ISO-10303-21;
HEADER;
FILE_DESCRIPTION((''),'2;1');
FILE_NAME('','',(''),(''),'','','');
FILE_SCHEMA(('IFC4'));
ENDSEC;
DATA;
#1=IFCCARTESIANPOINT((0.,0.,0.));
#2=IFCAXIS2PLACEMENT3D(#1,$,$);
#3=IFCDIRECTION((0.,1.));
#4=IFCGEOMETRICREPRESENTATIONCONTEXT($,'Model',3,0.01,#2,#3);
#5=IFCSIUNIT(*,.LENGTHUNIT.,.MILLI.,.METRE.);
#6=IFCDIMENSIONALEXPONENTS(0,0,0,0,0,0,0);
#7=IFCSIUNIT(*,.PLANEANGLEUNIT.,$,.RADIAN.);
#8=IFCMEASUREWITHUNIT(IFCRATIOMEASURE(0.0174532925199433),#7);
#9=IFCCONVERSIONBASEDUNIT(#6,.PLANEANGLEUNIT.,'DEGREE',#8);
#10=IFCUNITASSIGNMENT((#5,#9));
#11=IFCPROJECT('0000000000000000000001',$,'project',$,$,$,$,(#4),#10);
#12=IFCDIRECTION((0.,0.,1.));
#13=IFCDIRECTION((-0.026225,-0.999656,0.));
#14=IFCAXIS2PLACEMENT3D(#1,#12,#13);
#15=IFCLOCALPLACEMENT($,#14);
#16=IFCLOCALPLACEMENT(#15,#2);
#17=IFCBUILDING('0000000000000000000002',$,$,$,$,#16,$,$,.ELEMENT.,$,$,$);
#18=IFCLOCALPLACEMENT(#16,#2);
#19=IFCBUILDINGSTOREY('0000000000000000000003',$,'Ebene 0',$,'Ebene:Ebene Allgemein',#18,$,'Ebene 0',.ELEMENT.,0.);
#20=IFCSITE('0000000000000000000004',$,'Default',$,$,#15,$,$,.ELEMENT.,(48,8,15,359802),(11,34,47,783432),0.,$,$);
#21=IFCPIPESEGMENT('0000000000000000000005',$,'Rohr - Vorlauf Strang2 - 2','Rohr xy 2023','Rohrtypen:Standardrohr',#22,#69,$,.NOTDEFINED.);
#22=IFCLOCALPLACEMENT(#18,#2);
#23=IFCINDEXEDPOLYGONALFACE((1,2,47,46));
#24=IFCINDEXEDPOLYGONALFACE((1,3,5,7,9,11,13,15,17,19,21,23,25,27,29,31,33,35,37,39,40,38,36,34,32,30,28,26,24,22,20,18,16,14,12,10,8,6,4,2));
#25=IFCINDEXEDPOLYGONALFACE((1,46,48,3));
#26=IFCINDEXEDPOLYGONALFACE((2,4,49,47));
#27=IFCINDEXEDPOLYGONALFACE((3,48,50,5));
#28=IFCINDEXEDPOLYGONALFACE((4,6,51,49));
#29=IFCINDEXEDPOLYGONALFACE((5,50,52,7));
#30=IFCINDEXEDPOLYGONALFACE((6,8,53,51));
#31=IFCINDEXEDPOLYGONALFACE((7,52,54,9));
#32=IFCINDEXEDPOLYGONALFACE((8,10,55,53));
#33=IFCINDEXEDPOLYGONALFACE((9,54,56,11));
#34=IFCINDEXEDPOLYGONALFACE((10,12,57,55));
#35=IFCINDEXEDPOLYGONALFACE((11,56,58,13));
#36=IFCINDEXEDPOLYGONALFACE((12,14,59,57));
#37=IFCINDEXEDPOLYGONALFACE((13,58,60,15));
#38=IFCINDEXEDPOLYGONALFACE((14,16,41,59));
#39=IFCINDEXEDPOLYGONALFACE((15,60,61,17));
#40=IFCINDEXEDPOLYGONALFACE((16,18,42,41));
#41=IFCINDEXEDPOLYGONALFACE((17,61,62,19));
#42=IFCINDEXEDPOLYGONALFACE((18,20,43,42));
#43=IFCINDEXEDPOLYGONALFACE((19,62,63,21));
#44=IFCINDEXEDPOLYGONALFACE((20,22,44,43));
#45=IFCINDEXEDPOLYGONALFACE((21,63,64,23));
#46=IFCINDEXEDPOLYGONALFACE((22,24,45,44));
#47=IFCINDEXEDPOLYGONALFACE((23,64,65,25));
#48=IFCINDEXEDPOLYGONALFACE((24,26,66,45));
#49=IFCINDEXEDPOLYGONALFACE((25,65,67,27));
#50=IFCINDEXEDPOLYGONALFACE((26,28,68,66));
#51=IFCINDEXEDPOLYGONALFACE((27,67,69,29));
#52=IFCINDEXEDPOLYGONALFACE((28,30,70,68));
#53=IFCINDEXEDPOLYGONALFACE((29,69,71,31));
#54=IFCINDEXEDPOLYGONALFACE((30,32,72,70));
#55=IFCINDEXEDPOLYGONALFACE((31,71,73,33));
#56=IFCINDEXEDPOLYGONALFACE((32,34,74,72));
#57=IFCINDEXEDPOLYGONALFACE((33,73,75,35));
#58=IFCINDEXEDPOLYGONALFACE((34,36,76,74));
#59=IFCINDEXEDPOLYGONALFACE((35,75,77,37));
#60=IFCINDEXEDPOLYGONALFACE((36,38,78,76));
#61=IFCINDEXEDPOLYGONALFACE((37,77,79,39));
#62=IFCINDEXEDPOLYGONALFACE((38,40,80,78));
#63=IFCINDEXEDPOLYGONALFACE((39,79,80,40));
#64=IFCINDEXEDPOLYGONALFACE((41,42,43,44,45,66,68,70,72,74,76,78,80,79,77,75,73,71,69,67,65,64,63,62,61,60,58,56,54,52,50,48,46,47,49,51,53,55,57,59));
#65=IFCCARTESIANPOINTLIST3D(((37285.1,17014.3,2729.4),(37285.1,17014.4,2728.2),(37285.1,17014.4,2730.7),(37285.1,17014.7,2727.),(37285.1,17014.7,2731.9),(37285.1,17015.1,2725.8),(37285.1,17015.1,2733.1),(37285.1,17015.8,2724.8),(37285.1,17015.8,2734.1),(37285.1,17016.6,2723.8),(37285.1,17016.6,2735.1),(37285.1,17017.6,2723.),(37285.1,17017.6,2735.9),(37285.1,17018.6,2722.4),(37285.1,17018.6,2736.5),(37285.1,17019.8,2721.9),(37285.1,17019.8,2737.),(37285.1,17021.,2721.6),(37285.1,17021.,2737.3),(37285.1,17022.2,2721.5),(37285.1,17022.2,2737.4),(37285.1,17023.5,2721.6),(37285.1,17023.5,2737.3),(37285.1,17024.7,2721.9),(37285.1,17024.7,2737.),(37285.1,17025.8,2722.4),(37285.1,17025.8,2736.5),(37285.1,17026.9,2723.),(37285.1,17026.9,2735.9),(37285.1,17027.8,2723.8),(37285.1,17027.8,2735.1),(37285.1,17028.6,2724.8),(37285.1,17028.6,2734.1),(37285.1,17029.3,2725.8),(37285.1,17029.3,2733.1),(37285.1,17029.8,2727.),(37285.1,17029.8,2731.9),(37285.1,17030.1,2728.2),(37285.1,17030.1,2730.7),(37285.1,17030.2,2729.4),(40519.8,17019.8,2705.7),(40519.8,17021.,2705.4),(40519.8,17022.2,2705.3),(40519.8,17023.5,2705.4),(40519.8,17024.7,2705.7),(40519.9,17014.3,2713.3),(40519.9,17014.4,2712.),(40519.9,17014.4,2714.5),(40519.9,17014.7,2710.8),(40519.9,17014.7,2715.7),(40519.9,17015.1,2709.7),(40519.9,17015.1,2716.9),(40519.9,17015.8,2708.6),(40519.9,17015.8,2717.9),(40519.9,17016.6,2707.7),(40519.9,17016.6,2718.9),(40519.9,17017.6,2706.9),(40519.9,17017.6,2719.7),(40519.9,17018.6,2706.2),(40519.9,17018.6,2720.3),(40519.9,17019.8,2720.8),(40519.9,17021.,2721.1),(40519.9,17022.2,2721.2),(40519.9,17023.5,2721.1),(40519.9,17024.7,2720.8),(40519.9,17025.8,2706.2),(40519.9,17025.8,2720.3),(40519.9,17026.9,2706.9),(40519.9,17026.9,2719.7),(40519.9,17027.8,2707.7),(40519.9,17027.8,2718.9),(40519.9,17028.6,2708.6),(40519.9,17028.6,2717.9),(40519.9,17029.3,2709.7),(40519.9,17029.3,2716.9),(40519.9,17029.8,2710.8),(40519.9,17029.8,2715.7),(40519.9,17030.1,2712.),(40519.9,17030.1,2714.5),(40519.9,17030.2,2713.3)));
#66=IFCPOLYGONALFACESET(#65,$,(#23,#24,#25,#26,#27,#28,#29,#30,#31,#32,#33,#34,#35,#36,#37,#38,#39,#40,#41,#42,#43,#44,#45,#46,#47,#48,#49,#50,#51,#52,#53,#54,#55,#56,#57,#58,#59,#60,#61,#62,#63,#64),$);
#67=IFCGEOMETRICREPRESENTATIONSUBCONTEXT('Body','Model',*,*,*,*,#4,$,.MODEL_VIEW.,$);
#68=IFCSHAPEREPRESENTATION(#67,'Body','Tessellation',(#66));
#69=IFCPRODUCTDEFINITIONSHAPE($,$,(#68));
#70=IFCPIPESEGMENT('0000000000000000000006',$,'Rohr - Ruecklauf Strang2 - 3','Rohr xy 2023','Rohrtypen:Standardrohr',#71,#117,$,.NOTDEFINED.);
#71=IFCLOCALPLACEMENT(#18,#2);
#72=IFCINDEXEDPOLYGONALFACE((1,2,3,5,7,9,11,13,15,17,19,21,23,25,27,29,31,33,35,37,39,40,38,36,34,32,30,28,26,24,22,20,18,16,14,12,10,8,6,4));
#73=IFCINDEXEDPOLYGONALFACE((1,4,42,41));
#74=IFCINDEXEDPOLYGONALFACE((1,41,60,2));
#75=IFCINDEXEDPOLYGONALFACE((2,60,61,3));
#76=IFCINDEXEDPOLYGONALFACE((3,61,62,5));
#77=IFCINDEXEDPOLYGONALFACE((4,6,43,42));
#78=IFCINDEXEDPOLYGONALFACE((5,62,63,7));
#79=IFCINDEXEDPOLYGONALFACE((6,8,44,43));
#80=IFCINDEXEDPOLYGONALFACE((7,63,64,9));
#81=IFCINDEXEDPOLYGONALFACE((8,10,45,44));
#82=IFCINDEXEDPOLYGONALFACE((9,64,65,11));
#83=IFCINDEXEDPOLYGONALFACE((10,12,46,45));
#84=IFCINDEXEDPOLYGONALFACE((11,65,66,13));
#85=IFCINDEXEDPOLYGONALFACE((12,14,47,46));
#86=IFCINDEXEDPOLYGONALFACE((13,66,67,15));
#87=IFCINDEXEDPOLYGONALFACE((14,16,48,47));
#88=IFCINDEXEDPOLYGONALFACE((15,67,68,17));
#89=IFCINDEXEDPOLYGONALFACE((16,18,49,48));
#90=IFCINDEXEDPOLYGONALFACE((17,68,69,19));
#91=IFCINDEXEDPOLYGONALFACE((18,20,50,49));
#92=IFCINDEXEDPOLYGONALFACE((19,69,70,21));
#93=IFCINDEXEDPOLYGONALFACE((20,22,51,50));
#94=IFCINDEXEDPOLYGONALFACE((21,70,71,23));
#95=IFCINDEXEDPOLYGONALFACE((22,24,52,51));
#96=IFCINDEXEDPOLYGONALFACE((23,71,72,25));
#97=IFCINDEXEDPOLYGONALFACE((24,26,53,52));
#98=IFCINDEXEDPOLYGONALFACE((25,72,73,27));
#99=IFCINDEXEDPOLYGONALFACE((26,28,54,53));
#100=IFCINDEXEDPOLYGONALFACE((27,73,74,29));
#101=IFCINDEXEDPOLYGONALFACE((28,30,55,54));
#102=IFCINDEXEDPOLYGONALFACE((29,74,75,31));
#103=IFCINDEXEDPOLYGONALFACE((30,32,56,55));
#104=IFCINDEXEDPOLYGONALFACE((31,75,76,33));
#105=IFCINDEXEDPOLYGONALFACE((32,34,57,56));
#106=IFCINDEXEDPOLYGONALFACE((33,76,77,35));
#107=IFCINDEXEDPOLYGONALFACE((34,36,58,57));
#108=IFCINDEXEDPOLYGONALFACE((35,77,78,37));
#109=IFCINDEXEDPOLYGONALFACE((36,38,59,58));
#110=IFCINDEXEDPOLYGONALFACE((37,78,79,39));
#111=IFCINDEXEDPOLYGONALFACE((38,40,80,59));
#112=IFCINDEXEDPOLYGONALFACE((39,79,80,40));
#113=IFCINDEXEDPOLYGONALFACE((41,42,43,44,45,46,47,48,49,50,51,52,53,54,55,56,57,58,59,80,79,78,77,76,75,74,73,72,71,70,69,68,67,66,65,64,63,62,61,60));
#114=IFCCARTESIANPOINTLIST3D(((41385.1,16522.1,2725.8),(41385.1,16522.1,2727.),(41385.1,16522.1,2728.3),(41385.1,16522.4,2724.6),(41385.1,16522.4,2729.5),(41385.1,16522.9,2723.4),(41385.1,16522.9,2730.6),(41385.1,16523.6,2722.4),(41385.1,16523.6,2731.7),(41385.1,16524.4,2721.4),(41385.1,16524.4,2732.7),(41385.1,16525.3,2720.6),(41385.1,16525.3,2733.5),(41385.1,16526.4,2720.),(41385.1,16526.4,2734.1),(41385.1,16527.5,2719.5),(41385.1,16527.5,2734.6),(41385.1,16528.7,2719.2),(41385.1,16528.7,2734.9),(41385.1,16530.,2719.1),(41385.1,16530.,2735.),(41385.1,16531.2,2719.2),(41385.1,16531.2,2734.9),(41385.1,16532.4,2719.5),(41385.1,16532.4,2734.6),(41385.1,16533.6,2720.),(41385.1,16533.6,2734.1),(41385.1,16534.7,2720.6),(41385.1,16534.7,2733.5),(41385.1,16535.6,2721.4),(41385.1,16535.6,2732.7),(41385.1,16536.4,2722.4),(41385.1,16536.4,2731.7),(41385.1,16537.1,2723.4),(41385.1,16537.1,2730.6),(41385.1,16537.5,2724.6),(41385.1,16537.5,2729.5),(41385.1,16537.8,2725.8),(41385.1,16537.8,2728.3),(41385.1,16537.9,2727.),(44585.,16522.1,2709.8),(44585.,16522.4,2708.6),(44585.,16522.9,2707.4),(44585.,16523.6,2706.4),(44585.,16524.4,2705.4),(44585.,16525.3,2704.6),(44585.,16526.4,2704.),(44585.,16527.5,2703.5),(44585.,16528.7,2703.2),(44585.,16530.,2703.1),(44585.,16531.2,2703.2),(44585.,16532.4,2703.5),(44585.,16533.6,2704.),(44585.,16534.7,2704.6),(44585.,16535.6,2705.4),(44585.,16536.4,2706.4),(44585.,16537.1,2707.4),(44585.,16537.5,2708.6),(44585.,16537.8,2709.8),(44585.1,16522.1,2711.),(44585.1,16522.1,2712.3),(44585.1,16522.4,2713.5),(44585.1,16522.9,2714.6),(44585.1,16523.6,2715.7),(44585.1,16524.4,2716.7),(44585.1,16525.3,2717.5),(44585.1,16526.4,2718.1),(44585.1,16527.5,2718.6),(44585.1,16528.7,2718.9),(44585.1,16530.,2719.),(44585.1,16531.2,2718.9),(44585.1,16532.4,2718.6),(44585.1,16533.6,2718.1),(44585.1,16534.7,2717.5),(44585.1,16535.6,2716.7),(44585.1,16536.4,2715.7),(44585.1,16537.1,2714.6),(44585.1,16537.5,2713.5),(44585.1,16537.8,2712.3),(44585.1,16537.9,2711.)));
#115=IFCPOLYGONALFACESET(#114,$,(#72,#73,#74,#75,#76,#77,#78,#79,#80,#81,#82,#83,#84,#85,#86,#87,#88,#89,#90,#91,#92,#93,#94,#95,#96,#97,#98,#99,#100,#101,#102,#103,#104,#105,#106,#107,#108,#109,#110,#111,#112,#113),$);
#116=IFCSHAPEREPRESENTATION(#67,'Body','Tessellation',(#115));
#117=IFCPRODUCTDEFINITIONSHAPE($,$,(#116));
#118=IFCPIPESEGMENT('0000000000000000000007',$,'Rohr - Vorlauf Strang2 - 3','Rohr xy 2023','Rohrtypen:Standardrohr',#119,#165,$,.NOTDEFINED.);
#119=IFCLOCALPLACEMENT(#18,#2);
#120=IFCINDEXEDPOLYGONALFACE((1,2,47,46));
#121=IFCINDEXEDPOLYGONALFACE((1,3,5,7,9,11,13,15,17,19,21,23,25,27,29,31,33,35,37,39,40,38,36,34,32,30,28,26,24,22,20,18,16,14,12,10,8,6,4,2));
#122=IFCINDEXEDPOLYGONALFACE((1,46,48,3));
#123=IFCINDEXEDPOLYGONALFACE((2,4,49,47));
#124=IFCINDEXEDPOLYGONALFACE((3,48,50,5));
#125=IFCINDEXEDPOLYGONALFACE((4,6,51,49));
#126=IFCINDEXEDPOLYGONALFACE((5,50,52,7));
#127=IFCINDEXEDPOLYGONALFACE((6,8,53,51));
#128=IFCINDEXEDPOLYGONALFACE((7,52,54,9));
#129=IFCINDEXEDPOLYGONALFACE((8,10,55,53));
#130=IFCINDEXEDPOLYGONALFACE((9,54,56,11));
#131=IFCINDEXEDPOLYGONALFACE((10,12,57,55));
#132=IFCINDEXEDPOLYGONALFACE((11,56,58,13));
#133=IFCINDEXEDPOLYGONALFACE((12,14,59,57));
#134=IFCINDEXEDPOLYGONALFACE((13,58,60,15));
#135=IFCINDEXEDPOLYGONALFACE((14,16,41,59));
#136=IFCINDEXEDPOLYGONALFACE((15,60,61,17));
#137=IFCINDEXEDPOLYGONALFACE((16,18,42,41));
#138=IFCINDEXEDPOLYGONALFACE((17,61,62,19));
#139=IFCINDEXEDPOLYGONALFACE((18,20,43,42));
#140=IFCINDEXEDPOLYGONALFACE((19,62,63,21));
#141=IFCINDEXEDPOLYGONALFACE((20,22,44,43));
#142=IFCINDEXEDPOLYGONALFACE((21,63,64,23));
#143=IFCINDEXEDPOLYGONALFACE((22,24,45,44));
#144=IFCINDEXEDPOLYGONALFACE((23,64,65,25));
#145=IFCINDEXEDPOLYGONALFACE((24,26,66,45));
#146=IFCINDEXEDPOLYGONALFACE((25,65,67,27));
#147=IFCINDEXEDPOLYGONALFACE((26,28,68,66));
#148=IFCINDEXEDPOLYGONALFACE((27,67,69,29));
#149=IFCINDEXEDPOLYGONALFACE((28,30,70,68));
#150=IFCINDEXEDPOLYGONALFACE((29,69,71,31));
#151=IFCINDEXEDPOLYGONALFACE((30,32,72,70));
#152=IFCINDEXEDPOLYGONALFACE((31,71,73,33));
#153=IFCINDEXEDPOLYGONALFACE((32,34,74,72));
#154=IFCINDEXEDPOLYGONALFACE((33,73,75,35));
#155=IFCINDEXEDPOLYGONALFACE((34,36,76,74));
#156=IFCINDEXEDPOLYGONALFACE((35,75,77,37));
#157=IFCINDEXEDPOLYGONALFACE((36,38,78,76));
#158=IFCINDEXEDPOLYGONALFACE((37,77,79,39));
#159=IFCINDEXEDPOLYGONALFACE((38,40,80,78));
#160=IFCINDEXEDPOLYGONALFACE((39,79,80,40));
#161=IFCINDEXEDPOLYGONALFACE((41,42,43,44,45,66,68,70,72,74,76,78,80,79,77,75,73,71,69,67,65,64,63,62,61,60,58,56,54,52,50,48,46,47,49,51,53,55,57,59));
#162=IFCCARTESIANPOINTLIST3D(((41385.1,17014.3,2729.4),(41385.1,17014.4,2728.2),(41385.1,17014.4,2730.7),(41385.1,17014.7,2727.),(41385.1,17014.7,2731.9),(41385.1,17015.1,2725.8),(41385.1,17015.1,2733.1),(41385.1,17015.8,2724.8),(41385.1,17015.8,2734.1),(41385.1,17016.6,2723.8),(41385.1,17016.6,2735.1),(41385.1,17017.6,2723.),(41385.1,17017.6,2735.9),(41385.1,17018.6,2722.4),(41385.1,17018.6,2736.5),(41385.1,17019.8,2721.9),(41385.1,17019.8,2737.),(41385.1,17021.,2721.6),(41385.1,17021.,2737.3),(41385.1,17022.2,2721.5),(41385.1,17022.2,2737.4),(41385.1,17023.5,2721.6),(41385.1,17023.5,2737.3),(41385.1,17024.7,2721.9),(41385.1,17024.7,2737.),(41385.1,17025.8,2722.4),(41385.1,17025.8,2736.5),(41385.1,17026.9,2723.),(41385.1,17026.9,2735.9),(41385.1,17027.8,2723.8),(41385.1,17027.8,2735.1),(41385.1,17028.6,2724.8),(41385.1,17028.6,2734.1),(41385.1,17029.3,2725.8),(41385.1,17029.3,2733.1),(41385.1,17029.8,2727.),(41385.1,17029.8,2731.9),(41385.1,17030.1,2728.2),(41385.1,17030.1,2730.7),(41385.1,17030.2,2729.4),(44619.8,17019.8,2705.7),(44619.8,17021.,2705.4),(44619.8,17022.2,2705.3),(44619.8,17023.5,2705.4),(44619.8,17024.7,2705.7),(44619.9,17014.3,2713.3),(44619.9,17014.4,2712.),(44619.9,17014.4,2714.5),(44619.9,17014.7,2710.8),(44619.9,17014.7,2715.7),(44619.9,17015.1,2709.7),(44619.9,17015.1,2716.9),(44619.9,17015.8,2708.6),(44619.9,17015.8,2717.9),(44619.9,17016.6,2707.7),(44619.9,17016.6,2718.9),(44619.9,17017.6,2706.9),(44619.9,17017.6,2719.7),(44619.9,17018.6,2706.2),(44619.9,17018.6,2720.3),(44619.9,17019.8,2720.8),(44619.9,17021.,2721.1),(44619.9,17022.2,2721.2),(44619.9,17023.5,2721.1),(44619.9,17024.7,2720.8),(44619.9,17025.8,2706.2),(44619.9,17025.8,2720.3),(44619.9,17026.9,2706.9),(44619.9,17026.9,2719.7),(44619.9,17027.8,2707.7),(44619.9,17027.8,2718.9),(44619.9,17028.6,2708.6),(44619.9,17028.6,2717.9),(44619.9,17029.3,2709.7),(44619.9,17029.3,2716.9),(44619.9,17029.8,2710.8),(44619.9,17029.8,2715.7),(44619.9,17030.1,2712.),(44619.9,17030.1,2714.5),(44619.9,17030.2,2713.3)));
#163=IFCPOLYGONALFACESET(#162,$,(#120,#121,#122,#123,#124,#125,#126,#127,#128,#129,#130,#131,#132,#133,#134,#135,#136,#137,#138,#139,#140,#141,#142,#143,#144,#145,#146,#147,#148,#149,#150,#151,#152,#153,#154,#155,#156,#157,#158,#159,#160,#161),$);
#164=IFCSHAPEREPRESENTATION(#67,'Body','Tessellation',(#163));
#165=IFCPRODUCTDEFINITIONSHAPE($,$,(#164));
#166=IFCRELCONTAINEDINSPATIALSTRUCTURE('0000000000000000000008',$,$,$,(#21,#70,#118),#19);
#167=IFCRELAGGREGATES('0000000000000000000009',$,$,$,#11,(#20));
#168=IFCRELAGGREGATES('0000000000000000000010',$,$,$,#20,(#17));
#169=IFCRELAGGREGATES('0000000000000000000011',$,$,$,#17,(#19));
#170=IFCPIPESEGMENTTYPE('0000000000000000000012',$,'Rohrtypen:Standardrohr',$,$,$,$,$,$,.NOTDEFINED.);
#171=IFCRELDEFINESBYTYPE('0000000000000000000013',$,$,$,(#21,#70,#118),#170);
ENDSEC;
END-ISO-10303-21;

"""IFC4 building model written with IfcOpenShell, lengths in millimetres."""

from ifc_helpers import new_model, entity, si_unit, converted_unit, direction, frame, origin, place, context, subcontext, project, spatial, indexed_curve, outline, extrude, type_object, element, save


model = new_model("IFC4")

# Units and contexts
model_context = context("Model", 3, precision=0.01, world=origin(), true_north=direction((0.0, 1.0)))
body_context = subcontext(model_context, "Body", "Model", "MODEL_VIEW")
ifc_project = project(units=[si_unit("LENGTHUNIT", "METRE", prefix="MILLI"), converted_unit("PLANEANGLEUNIT", "DEGREE", entity("IfcRatioMeasure", 0.0174532925199433), si_unit("PLANEANGLEUNIT", "RADIAN"), dimensions=[0, 0, 0, 0, 0, 0, 0])], contexts=[model_context])

# Site, building, storey
site_placement = place(None, frame((0.0, 0.0, 0.0), z_axis=(0.0, 0.0, 1.0), x_axis=(-0.026225, -0.999656, 0.0)))
site = spatial("IfcSite", under=ifc_project, at=site_placement, Name="Default", CompositionType="ELEMENT", RefLatitude=(48, 8, 15, 359802), RefLongitude=(11, 34, 47, 783432), RefElevation=0.0)
building_placement = place(site_placement, origin())
building = spatial("IfcBuilding", under=site, at=building_placement, CompositionType="ELEMENT")
storey_placement = place(building_placement, origin())
storey = spatial("IfcBuildingStorey", under=building, at=storey_placement, Name="Ebene 0", ObjectType="Ebene:Ebene Allgemein", LongName="Ebene 0", CompositionType="ELEMENT", Elevation=0.0)

# Pipe segments
pipe_segment_type = type_object("IfcPipeSegmentType", Name="Rohrtypen:Standardrohr", PredefinedType="NOTDEFINED")
pipe_segment_1_placement = place(storey_placement, origin())
element("IfcPipeSegment", 1, at=pipe_segment_1_placement, inside=storey, type_object=pipe_segment_type, Name="Rohr - Vorlauf Strang2 - 2", Description="Rohr xy 2023", ObjectType="Rohrtypen:Standardrohr", PredefinedType="NOTDEFINED", context=body_context, shape_type="SweptSolid", body=[
    extrude(outline(indexed_curve([(7.9, 0.0), (7.8, 1.2), (7.6, 2.5), (7.1, 3.6), (6.4, 4.7), (5.6, 5.6), (4.7, 6.4), (3.6, 7.1), (2.5, 7.6), (1.2, 7.8), (0.0, 7.9), (-1.2, 7.8), (-2.5, 7.6), (-3.6, 7.1), (-4.7, 6.4), (-5.6, 5.6), (-6.4, 4.7), (-7.1, 3.6), (-7.6, 2.5), (-7.8, 1.2), (-7.9, 0.0), (-7.8, -1.2), (-7.6, -2.5), (-7.1, -3.6), (-6.4, -4.7), (-5.6, -5.6), (-4.7, -6.4), (-3.6, -7.1), (-2.5, -7.6), (-1.2, -7.8), (0.0, -7.9), (1.2, -7.8), (2.5, -7.6), (3.6, -7.1), (4.7, -6.4), (5.6, -5.6), (6.4, -4.7), (7.1, -3.6), (7.6, -2.5), (7.8, -1.2), (7.9, 0.0)], self_intersect=False)), frame((40519.9, 17022.2, 2713.3), z_axis=(-0.999988, 0.0, 0.005), x_axis=(0.0, 1.0, 0.0)), (0.0, 0.0, 1.0), 3234.8),
])
pipe_segment_2_placement = place(storey_placement, origin())
element("IfcPipeSegment", 2, at=pipe_segment_2_placement, inside=storey, type_object=pipe_segment_type, Name="Rohr - Ruecklauf Strang2 - 3", Description="Rohr xy 2023", ObjectType="Rohrtypen:Standardrohr", PredefinedType="NOTDEFINED", context=body_context, shape_type="SweptSolid", body=[
    extrude(outline(indexed_curve([(7.9, 0.0), (7.8, 1.2), (7.6, 2.5), (7.1, 3.6), (6.4, 4.7), (5.6, 5.6), (4.7, 6.4), (3.6, 7.1), (2.5, 7.6), (1.2, 7.8), (0.0, 7.9), (-1.2, 7.8), (-2.5, 7.6), (-3.6, 7.1), (-4.7, 6.4), (-5.6, 5.6), (-6.4, 4.7), (-7.1, 3.6), (-7.6, 2.5), (-7.8, 1.2), (-7.9, 0.0), (-7.8, -1.2), (-7.6, -2.5), (-7.1, -3.6), (-6.4, -4.7), (-5.6, -5.6), (-4.7, -6.4), (-3.6, -7.1), (-2.5, -7.6), (-1.2, -7.8), (0.0, -7.9), (1.2, -7.8), (2.5, -7.6), (3.6, -7.1), (4.7, -6.4), (5.6, -5.6), (6.4, -4.7), (7.1, -3.6), (7.6, -2.5), (7.8, -1.2), (7.9, 0.0)], self_intersect=False)), frame((44585.1, 16530.0, 2711.0), z_axis=(-0.999988, 0.0, 0.005), x_axis=(0.0, 1.0, 0.0)), (0.0, 0.0, 1.0), 3200.0),
])
pipe_segment_3_placement = place(storey_placement, origin())
element("IfcPipeSegment", 3, at=pipe_segment_3_placement, inside=storey, type_object=pipe_segment_type, Name="Rohr - Vorlauf Strang2 - 3", Description="Rohr xy 2023", ObjectType="Rohrtypen:Standardrohr", PredefinedType="NOTDEFINED", context=body_context, shape_type="SweptSolid", body=[
    extrude(outline(indexed_curve([(7.9, 0.0), (7.8, 1.2), (7.6, 2.5), (7.1, 3.6), (6.4, 4.7), (5.6, 5.6), (4.7, 6.4), (3.6, 7.1), (2.5, 7.6), (1.2, 7.8), (0.0, 7.9), (-1.2, 7.8), (-2.5, 7.6), (-3.6, 7.1), (-4.7, 6.4), (-5.6, 5.6), (-6.4, 4.7), (-7.1, 3.6), (-7.6, 2.5), (-7.8, 1.2), (-7.9, 0.0), (-7.8, -1.2), (-7.6, -2.5), (-7.1, -3.6), (-6.4, -4.7), (-5.6, -5.6), (-4.7, -6.4), (-3.6, -7.1), (-2.5, -7.6), (-1.2, -7.8), (0.0, -7.9), (1.2, -7.8), (2.5, -7.6), (3.6, -7.1), (4.7, -6.4), (5.6, -5.6), (6.4, -4.7), (7.1, -3.6), (7.6, -2.5), (7.8, -1.2), (7.9, 0.0)], self_intersect=False)), frame((44619.9, 17022.2, 2713.3), z_axis=(-0.999988, 0.0, 0.005), x_axis=(0.0, 1.0, 0.0)), (0.0, 0.0, 1.0), 3234.8),
])

save(model, "model.ifc")
